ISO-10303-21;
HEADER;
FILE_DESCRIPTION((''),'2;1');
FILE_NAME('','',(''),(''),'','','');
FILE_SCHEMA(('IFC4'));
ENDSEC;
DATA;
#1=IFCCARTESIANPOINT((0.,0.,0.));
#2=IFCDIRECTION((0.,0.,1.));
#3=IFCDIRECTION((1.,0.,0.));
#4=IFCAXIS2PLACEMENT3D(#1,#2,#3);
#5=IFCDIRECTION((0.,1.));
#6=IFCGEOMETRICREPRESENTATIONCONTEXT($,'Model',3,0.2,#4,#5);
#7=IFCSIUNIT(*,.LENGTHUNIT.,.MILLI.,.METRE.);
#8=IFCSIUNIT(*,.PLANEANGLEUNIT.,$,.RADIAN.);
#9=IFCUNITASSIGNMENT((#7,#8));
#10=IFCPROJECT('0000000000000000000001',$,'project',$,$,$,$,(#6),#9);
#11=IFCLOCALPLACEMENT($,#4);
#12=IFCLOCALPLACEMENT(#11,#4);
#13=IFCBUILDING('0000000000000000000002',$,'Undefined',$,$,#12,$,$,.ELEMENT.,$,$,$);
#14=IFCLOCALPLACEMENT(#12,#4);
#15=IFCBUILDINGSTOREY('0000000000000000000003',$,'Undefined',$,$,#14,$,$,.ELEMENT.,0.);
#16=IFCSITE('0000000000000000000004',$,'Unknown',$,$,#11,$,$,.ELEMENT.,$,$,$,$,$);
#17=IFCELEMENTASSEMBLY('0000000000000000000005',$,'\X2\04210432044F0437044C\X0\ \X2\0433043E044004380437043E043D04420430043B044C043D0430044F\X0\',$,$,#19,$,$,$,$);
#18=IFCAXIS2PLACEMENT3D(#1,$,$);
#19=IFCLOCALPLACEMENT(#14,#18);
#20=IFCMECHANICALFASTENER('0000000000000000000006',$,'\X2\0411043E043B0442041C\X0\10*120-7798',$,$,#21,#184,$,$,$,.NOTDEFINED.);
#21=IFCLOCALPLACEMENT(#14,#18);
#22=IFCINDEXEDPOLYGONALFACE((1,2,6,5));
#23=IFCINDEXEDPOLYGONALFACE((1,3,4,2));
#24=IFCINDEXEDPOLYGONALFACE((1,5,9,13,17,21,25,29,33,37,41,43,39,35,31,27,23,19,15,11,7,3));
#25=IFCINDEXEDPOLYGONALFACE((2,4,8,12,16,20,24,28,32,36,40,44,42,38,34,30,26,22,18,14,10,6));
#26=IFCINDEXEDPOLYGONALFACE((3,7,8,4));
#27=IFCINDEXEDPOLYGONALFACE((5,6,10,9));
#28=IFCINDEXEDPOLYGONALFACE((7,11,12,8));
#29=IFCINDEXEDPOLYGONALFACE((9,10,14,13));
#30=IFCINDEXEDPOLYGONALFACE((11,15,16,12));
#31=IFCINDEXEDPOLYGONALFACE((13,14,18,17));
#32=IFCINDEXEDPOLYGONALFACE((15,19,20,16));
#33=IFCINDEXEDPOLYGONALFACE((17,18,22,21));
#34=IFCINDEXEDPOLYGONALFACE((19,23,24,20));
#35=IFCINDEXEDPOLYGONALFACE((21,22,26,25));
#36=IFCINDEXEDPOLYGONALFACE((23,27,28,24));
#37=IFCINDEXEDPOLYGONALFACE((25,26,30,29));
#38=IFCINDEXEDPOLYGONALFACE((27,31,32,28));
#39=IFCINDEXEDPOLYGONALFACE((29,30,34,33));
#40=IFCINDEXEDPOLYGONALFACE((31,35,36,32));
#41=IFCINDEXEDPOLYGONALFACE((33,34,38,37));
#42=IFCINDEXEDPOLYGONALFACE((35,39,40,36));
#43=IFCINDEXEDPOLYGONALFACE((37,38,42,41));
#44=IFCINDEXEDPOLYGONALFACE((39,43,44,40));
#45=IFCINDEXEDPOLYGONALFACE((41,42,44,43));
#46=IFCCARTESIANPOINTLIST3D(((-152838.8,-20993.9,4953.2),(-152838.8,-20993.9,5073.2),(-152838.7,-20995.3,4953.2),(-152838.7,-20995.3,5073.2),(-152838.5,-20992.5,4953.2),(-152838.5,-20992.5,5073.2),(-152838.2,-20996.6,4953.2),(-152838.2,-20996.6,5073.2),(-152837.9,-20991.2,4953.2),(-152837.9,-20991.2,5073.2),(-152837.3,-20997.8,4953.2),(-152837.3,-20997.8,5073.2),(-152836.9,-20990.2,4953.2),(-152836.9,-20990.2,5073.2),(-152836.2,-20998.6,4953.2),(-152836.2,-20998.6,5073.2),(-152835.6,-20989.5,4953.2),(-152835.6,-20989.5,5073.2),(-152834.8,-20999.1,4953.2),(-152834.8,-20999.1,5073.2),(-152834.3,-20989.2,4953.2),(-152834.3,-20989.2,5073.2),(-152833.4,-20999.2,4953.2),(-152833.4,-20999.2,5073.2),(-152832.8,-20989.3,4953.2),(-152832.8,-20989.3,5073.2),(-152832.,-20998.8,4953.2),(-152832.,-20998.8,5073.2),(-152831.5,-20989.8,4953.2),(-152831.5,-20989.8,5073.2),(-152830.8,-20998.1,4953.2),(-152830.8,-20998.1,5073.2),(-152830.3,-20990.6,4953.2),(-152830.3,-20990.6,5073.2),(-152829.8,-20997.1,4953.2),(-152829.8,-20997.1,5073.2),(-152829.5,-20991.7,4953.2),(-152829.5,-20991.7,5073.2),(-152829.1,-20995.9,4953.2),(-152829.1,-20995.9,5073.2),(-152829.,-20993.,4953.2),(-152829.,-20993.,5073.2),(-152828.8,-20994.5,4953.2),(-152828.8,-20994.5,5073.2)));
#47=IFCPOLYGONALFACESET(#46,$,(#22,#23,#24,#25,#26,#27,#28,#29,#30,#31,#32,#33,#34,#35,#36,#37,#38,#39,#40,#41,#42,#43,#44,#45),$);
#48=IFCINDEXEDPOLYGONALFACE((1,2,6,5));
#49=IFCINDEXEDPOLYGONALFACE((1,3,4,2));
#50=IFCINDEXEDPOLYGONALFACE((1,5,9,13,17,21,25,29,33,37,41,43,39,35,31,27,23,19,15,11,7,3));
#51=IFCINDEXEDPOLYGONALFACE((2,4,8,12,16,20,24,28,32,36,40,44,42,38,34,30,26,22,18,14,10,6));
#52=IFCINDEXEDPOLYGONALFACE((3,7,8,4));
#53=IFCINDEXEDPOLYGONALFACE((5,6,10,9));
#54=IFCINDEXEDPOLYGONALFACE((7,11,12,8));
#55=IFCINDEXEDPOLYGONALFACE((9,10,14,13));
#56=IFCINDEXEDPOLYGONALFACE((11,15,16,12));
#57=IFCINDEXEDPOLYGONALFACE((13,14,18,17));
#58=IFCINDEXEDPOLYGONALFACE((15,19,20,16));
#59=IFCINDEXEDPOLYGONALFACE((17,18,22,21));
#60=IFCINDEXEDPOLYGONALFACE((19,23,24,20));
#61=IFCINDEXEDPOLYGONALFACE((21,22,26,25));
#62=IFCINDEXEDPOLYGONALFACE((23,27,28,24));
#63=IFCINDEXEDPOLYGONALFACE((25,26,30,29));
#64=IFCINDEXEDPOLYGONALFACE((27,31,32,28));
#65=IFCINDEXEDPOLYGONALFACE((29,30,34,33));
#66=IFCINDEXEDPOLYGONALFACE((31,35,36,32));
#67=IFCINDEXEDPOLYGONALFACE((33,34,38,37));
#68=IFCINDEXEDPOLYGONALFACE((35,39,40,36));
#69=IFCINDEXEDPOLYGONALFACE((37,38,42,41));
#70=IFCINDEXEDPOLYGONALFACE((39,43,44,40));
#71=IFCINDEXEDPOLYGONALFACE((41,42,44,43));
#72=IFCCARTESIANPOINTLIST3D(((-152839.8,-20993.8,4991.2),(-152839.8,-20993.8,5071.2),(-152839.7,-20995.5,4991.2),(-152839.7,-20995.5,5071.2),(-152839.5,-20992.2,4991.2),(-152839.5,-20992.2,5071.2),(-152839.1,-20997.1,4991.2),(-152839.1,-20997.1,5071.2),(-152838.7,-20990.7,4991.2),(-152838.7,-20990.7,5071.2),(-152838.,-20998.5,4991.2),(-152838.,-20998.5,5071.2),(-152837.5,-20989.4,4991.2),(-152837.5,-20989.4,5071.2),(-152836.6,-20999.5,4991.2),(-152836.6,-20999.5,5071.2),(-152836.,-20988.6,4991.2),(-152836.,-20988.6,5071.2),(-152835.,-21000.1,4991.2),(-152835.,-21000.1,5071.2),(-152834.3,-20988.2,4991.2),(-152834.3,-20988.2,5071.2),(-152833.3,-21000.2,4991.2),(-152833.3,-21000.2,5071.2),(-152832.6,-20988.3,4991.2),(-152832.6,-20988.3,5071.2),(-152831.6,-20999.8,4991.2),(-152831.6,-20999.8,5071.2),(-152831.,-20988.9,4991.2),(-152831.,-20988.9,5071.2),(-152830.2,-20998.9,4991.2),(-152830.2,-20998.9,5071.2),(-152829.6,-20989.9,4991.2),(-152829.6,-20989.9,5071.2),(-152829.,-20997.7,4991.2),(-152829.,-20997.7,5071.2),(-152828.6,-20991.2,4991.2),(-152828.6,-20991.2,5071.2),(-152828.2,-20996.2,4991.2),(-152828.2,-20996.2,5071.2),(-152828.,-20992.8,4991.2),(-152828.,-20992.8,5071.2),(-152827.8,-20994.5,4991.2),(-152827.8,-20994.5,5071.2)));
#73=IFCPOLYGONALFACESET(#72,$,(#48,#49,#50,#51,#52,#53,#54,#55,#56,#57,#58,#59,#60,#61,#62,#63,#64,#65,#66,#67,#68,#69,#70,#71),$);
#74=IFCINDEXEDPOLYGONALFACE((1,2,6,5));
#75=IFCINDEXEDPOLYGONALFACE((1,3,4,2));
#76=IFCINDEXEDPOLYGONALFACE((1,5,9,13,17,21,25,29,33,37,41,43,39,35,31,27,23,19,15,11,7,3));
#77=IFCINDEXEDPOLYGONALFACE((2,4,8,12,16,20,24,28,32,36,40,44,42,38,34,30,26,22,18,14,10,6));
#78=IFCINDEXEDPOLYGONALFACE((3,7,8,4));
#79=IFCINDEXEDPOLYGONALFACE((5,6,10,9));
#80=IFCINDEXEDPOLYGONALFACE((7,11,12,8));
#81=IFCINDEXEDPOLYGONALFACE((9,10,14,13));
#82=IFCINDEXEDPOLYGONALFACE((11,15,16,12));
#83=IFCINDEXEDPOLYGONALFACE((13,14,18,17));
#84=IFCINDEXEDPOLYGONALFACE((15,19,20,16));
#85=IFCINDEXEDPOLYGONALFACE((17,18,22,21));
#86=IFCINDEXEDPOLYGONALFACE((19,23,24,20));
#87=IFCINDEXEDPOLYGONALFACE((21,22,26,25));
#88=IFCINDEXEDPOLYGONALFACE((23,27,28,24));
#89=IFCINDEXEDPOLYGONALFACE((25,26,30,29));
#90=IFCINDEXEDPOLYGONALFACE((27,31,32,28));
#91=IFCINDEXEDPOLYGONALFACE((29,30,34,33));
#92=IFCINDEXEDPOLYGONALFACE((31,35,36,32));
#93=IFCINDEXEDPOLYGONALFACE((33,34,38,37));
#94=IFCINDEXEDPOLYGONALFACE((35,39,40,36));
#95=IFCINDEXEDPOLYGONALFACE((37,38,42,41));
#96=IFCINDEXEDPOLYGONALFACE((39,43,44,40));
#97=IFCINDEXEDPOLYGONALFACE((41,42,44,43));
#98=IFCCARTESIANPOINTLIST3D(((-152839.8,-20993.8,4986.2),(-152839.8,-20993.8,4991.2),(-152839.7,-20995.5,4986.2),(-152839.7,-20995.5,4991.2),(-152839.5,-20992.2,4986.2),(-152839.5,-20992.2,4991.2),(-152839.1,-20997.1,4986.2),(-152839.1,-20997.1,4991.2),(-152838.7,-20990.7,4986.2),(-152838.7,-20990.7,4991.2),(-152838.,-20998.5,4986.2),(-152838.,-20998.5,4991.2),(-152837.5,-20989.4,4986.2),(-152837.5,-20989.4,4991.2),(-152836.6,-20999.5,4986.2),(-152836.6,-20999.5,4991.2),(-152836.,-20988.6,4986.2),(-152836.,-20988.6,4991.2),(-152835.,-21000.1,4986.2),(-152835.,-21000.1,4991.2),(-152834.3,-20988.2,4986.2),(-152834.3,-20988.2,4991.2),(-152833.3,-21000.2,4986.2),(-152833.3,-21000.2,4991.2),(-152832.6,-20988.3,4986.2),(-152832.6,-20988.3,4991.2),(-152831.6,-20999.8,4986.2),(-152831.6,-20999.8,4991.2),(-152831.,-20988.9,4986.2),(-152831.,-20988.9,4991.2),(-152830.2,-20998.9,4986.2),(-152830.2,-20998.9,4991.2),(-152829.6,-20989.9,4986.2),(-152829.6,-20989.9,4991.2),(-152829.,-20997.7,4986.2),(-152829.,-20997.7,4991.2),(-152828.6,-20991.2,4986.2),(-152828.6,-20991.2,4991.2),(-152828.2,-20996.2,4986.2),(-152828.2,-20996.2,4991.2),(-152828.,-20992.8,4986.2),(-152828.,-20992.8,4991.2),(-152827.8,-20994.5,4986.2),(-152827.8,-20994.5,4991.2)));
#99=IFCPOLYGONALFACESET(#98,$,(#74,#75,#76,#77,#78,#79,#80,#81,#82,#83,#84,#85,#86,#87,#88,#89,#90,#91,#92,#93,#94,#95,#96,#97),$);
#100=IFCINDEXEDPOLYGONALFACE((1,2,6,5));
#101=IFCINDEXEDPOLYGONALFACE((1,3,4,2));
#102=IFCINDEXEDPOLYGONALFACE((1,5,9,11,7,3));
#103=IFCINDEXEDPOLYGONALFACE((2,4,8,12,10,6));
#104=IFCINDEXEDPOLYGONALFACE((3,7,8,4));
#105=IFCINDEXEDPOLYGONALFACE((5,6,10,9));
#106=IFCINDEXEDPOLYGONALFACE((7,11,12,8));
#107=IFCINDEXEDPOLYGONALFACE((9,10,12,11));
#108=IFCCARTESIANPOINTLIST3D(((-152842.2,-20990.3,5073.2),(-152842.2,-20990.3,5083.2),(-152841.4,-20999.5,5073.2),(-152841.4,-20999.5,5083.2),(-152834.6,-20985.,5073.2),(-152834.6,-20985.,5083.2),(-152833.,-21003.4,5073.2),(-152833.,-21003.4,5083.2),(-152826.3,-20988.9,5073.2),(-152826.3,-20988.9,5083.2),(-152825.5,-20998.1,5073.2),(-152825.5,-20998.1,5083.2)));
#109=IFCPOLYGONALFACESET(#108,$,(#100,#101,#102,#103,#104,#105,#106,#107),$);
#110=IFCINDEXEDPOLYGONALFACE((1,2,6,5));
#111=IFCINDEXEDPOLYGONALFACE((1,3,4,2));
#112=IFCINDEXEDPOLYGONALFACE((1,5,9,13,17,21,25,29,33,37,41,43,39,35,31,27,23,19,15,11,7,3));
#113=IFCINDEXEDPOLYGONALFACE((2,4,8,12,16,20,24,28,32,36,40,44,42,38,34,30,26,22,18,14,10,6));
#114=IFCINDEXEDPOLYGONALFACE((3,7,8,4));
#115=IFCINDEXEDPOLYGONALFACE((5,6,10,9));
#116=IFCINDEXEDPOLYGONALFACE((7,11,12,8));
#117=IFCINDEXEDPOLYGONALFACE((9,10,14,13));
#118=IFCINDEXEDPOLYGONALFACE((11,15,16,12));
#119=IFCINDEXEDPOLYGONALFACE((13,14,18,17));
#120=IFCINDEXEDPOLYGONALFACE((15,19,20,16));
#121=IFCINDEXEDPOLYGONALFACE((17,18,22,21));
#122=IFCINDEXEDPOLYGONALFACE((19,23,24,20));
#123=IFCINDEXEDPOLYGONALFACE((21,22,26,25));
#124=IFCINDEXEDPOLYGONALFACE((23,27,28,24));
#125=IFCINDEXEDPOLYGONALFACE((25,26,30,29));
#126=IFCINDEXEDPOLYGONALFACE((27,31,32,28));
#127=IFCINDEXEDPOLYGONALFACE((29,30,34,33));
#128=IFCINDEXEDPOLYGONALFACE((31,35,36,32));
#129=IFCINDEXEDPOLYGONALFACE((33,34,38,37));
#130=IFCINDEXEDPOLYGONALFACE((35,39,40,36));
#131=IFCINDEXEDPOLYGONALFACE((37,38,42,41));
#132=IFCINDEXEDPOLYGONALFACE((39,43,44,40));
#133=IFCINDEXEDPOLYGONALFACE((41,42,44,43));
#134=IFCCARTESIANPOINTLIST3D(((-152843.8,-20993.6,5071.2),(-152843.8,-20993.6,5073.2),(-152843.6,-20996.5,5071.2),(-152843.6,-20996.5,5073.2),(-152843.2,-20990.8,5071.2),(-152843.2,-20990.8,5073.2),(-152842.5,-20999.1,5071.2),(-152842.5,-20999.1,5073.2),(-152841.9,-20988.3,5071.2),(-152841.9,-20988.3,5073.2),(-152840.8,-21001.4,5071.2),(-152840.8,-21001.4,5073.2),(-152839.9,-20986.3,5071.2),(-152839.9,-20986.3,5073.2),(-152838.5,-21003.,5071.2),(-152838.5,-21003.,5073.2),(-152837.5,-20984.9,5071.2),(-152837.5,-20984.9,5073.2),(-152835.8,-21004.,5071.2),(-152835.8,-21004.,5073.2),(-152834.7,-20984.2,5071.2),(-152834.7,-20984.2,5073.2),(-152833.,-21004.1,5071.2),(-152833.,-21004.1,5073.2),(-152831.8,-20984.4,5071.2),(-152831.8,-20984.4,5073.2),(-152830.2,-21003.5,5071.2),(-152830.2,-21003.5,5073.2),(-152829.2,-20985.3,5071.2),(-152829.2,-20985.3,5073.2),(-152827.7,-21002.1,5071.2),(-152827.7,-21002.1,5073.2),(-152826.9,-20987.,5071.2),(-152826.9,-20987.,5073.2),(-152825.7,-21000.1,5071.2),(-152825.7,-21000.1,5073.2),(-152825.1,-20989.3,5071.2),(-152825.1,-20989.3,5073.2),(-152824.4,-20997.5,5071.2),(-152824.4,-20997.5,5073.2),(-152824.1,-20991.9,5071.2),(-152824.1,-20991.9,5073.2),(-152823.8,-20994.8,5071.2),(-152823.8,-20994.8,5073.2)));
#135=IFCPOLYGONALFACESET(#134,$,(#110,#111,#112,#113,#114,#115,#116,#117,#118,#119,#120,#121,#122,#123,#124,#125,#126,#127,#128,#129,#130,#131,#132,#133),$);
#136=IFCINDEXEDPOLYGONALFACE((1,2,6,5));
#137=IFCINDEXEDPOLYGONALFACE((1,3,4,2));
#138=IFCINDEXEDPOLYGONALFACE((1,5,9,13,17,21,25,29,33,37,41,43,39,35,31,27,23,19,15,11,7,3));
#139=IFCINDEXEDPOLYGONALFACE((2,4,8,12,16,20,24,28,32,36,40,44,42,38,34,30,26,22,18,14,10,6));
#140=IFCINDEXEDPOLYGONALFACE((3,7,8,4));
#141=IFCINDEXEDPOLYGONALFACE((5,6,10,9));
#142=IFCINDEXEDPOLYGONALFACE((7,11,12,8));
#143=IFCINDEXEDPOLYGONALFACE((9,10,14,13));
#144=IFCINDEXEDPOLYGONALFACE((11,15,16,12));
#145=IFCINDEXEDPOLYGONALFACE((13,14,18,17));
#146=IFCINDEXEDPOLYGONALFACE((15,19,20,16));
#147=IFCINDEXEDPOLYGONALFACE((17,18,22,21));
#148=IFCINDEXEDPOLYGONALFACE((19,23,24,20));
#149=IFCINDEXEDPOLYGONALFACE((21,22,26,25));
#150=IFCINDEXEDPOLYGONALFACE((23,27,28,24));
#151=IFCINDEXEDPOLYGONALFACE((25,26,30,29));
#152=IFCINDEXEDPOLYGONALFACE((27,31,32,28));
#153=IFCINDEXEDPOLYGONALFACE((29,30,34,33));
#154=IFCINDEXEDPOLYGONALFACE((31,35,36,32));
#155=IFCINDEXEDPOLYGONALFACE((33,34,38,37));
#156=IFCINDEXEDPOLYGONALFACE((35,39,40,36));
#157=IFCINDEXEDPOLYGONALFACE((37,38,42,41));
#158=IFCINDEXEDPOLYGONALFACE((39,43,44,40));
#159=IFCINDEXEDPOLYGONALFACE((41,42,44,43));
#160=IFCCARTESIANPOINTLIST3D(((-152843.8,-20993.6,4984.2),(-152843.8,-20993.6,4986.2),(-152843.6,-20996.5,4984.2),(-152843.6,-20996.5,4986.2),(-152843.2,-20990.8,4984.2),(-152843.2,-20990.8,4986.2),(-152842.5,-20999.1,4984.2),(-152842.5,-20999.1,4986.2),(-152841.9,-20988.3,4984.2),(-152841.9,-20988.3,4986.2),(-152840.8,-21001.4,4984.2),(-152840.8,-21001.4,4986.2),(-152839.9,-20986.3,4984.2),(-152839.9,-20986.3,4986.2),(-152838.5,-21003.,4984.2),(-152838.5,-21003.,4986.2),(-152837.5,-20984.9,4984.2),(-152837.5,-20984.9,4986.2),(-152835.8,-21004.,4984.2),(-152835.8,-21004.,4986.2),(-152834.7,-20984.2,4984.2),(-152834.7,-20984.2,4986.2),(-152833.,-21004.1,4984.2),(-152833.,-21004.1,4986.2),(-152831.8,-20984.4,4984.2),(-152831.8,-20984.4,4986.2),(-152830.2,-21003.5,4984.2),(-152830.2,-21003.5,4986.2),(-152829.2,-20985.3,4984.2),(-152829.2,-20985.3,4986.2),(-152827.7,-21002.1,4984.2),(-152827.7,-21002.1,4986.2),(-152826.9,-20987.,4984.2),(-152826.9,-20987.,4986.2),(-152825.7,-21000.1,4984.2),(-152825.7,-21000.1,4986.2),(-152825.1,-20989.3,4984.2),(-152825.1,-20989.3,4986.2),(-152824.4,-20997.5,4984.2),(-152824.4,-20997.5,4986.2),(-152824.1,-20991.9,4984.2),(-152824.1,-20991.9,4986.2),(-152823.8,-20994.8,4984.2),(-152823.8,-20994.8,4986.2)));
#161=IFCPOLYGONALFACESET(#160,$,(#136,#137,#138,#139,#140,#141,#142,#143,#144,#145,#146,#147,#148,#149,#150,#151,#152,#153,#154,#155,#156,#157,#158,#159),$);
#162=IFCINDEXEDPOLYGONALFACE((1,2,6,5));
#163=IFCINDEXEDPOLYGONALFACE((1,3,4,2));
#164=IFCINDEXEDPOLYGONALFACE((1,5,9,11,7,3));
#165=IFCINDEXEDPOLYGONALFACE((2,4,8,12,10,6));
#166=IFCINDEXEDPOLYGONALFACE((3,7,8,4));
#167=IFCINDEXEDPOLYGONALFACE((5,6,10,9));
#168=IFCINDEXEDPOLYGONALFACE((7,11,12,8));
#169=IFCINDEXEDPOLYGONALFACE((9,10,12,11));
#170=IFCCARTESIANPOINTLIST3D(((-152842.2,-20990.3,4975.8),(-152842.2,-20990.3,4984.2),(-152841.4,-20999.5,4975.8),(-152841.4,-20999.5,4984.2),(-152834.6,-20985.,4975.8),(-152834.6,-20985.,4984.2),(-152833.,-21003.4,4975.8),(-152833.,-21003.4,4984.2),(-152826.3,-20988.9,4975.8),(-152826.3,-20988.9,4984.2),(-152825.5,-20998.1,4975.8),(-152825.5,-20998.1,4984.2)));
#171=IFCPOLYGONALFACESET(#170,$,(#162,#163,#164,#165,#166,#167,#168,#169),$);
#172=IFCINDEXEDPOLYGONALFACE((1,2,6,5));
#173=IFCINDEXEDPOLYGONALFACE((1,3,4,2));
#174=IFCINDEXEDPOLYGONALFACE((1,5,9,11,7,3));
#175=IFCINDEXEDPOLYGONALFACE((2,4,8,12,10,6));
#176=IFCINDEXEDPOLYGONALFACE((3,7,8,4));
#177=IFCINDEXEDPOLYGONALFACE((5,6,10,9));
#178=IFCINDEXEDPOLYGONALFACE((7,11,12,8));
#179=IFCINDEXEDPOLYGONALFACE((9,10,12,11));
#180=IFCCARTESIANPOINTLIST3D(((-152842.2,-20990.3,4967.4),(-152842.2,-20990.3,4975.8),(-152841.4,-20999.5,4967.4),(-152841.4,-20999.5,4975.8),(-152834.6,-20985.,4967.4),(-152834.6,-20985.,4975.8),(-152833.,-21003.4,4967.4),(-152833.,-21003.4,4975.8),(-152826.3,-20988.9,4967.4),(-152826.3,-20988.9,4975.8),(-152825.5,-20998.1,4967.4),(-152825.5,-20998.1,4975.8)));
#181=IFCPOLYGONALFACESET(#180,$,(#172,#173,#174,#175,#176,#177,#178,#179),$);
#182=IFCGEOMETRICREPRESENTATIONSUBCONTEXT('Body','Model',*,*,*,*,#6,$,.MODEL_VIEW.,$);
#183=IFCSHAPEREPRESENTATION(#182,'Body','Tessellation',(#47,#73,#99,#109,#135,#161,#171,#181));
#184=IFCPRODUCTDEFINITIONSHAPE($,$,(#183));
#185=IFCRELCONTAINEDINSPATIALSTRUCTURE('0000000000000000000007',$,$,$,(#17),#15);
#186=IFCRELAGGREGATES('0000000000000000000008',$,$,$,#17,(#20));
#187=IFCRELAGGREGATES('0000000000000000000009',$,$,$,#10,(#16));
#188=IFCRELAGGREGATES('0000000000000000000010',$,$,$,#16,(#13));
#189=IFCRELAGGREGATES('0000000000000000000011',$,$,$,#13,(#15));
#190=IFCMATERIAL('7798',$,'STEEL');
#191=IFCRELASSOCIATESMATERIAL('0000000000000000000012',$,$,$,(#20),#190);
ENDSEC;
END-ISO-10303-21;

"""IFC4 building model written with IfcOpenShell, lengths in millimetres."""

from ifc_helpers import new_model, si_unit, direction, frame, origin_with_axes, place, context, subcontext, project, spatial, line, arc, indexed_curve, outline, extrude, source, transform, mapped, material, element, aggregate, save


model = new_model("IFC4")

# Units and contexts
model_context = context("Model", 3, precision=0.2, world=origin_with_axes(), true_north=direction((0.0, 1.0)))
body_context = subcontext(model_context, "Body", "Model", "MODEL_VIEW")
ifc_project = project(units=[si_unit("LENGTHUNIT", "METRE", prefix="MILLI"), si_unit("PLANEANGLEUNIT", "RADIAN")], contexts=[model_context])

# Site, building, storey
site_placement = place(None, origin_with_axes())
site = spatial("IfcSite", under=ifc_project, at=site_placement, Name="Unknown", CompositionType="ELEMENT")
building_placement = place(site_placement, origin_with_axes())
building = spatial("IfcBuilding", under=site, at=building_placement, Name="Undefined", CompositionType="ELEMENT")
storey_placement = place(building_placement, origin_with_axes())
storey = spatial("IfcBuildingStorey", under=building, at=storey_placement, Name="Undefined", CompositionType="ELEMENT", Elevation=0.0)

# Shared definitions
ifc_material_1 = material(Name="7798", Category="STEEL")

# Element assembly, mechanical fastener
assembly_1_placement = place(storey_placement, frame((-153883.9, -21084.9, 5031.2), z_axis=(0.086114, -0.996285, 0.0), x_axis=(0.996285, 0.086114, 0.0)))
assembly_1 = element("IfcElementAssembly", 1, at=assembly_1_placement, inside=storey, Name="Связь горизонтальная")
shared_shape_1 = source(origin_with_axes(), body_context, "Body", "SweptSolid", [
    extrude(outline(indexed_curve([(5.0, 0.0), (0.0, 5.0), (-5.0, 0.0), (0.0, -5.0)], segments=[arc(1, 2, 3), arc(3, 4, 1)])), frame((0.0, 0.0, 87.0), z_axis=(0.0, 0.0, -1.0), x_axis=(0.0, 1.0, 0.0)), (0.0, 0.0, 1.0), 120.0),
    extrude(outline(indexed_curve([(6.0, 0.0), (0.0, 6.0), (-6.0, 0.0), (0.0, -6.0)], segments=[arc(1, 2, 3), arc(3, 4, 1)])), frame((0.0, 0.0, 85.0), z_axis=(0.0, 0.0, -1.0), x_axis=(0.0, 1.0, 0.0)), (0.0, 0.0, 1.0), 80.0),
    extrude(outline(indexed_curve([(6.0, 0.0), (0.0, 6.0), (-6.0, 0.0), (0.0, -6.0)], segments=[arc(1, 2, 3), arc(3, 4, 1)])), frame((0.0, 0.0, 5.0), z_axis=(0.0, 0.0, -1.0), x_axis=(0.0, 1.0, 0.0)), (0.0, 0.0, 1.0), 5.0),
    extrude(outline(indexed_curve([(9.2, 0.0), (4.6, 8.0), (-4.6, 8.0), (-9.2, 0.0), (-4.6, -8.0), (4.6, -8.0)], segments=[line(1, 2, 3, 4, 5, 6, 1)])), frame((0.0, 0.0, 97.0), z_axis=(0.0, 0.0, -1.0), x_axis=(0.0, 1.0, 0.0)), (0.0, 0.0, 1.0), 10.0),
    extrude(outline(indexed_curve([(10.0, 0.0), (0.0, 10.0), (-10.0, 0.0), (0.0, -10.0)], segments=[arc(1, 2, 3), arc(3, 4, 1)])), frame((0.0, 0.0, 87.0), z_axis=(0.0, 0.0, -1.0), x_axis=(0.0, 1.0, 0.0)), (0.0, 0.0, 1.0), 2.0),
    extrude(outline(indexed_curve([(10.0, 0.0), (0.0, 10.0), (-10.0, 0.0), (0.0, -10.0)], segments=[arc(1, 2, 3), arc(3, 4, 1)])), frame((0.0, 0.0, 0.0), z_axis=(0.0, 0.0, -1.0), x_axis=(0.0, 1.0, 0.0)), (0.0, 0.0, 1.0), 2.0),
    extrude(outline(indexed_curve([(9.2, 0.0), (4.6, 8.0), (-4.6, 8.0), (-9.2, 0.0), (-4.6, -8.0), (4.6, -8.0)], segments=[line(1, 2, 3, 4, 5, 6, 1)])), frame((0.0, 0.0, -2.0), z_axis=(0.0, 0.0, -1.0), x_axis=(0.0, 1.0, 0.0)), (0.0, 0.0, 1.0), 8.4),
    extrude(outline(indexed_curve([(9.2, 0.0), (4.6, 8.0), (-4.6, 8.0), (-9.2, 0.0), (-4.6, -8.0), (4.6, -8.0)], segments=[line(1, 2, 3, 4, 5, 6, 1)])), frame((0.0, 0.0, -10.4), z_axis=(0.0, 0.0, -1.0), x_axis=(0.0, 1.0, 0.0)), (0.0, 0.0, 1.0), 8.4),
])
mechanical_fastener_1_placement = place(assembly_1_placement, frame((1054.0, -45.0, 0.0), z_axis=(0.0, 1.0, 0.0), x_axis=(1.0, 0.0, 0.0)))
mechanical_fastener_1 = element("IfcMechanicalFastener", 2, at=mechanical_fastener_1_placement, material=ifc_material_1, Name="БолтМ10*120-7798", PredefinedType="NOTDEFINED", context=body_context, shape_type="MappedRepresentation", body=[
    mapped(shared_shape_1, transform((0.0, 0.0, 0.0))),
])
aggregate(assembly_1, [mechanical_fastener_1])

save(model, "model.ifc")
